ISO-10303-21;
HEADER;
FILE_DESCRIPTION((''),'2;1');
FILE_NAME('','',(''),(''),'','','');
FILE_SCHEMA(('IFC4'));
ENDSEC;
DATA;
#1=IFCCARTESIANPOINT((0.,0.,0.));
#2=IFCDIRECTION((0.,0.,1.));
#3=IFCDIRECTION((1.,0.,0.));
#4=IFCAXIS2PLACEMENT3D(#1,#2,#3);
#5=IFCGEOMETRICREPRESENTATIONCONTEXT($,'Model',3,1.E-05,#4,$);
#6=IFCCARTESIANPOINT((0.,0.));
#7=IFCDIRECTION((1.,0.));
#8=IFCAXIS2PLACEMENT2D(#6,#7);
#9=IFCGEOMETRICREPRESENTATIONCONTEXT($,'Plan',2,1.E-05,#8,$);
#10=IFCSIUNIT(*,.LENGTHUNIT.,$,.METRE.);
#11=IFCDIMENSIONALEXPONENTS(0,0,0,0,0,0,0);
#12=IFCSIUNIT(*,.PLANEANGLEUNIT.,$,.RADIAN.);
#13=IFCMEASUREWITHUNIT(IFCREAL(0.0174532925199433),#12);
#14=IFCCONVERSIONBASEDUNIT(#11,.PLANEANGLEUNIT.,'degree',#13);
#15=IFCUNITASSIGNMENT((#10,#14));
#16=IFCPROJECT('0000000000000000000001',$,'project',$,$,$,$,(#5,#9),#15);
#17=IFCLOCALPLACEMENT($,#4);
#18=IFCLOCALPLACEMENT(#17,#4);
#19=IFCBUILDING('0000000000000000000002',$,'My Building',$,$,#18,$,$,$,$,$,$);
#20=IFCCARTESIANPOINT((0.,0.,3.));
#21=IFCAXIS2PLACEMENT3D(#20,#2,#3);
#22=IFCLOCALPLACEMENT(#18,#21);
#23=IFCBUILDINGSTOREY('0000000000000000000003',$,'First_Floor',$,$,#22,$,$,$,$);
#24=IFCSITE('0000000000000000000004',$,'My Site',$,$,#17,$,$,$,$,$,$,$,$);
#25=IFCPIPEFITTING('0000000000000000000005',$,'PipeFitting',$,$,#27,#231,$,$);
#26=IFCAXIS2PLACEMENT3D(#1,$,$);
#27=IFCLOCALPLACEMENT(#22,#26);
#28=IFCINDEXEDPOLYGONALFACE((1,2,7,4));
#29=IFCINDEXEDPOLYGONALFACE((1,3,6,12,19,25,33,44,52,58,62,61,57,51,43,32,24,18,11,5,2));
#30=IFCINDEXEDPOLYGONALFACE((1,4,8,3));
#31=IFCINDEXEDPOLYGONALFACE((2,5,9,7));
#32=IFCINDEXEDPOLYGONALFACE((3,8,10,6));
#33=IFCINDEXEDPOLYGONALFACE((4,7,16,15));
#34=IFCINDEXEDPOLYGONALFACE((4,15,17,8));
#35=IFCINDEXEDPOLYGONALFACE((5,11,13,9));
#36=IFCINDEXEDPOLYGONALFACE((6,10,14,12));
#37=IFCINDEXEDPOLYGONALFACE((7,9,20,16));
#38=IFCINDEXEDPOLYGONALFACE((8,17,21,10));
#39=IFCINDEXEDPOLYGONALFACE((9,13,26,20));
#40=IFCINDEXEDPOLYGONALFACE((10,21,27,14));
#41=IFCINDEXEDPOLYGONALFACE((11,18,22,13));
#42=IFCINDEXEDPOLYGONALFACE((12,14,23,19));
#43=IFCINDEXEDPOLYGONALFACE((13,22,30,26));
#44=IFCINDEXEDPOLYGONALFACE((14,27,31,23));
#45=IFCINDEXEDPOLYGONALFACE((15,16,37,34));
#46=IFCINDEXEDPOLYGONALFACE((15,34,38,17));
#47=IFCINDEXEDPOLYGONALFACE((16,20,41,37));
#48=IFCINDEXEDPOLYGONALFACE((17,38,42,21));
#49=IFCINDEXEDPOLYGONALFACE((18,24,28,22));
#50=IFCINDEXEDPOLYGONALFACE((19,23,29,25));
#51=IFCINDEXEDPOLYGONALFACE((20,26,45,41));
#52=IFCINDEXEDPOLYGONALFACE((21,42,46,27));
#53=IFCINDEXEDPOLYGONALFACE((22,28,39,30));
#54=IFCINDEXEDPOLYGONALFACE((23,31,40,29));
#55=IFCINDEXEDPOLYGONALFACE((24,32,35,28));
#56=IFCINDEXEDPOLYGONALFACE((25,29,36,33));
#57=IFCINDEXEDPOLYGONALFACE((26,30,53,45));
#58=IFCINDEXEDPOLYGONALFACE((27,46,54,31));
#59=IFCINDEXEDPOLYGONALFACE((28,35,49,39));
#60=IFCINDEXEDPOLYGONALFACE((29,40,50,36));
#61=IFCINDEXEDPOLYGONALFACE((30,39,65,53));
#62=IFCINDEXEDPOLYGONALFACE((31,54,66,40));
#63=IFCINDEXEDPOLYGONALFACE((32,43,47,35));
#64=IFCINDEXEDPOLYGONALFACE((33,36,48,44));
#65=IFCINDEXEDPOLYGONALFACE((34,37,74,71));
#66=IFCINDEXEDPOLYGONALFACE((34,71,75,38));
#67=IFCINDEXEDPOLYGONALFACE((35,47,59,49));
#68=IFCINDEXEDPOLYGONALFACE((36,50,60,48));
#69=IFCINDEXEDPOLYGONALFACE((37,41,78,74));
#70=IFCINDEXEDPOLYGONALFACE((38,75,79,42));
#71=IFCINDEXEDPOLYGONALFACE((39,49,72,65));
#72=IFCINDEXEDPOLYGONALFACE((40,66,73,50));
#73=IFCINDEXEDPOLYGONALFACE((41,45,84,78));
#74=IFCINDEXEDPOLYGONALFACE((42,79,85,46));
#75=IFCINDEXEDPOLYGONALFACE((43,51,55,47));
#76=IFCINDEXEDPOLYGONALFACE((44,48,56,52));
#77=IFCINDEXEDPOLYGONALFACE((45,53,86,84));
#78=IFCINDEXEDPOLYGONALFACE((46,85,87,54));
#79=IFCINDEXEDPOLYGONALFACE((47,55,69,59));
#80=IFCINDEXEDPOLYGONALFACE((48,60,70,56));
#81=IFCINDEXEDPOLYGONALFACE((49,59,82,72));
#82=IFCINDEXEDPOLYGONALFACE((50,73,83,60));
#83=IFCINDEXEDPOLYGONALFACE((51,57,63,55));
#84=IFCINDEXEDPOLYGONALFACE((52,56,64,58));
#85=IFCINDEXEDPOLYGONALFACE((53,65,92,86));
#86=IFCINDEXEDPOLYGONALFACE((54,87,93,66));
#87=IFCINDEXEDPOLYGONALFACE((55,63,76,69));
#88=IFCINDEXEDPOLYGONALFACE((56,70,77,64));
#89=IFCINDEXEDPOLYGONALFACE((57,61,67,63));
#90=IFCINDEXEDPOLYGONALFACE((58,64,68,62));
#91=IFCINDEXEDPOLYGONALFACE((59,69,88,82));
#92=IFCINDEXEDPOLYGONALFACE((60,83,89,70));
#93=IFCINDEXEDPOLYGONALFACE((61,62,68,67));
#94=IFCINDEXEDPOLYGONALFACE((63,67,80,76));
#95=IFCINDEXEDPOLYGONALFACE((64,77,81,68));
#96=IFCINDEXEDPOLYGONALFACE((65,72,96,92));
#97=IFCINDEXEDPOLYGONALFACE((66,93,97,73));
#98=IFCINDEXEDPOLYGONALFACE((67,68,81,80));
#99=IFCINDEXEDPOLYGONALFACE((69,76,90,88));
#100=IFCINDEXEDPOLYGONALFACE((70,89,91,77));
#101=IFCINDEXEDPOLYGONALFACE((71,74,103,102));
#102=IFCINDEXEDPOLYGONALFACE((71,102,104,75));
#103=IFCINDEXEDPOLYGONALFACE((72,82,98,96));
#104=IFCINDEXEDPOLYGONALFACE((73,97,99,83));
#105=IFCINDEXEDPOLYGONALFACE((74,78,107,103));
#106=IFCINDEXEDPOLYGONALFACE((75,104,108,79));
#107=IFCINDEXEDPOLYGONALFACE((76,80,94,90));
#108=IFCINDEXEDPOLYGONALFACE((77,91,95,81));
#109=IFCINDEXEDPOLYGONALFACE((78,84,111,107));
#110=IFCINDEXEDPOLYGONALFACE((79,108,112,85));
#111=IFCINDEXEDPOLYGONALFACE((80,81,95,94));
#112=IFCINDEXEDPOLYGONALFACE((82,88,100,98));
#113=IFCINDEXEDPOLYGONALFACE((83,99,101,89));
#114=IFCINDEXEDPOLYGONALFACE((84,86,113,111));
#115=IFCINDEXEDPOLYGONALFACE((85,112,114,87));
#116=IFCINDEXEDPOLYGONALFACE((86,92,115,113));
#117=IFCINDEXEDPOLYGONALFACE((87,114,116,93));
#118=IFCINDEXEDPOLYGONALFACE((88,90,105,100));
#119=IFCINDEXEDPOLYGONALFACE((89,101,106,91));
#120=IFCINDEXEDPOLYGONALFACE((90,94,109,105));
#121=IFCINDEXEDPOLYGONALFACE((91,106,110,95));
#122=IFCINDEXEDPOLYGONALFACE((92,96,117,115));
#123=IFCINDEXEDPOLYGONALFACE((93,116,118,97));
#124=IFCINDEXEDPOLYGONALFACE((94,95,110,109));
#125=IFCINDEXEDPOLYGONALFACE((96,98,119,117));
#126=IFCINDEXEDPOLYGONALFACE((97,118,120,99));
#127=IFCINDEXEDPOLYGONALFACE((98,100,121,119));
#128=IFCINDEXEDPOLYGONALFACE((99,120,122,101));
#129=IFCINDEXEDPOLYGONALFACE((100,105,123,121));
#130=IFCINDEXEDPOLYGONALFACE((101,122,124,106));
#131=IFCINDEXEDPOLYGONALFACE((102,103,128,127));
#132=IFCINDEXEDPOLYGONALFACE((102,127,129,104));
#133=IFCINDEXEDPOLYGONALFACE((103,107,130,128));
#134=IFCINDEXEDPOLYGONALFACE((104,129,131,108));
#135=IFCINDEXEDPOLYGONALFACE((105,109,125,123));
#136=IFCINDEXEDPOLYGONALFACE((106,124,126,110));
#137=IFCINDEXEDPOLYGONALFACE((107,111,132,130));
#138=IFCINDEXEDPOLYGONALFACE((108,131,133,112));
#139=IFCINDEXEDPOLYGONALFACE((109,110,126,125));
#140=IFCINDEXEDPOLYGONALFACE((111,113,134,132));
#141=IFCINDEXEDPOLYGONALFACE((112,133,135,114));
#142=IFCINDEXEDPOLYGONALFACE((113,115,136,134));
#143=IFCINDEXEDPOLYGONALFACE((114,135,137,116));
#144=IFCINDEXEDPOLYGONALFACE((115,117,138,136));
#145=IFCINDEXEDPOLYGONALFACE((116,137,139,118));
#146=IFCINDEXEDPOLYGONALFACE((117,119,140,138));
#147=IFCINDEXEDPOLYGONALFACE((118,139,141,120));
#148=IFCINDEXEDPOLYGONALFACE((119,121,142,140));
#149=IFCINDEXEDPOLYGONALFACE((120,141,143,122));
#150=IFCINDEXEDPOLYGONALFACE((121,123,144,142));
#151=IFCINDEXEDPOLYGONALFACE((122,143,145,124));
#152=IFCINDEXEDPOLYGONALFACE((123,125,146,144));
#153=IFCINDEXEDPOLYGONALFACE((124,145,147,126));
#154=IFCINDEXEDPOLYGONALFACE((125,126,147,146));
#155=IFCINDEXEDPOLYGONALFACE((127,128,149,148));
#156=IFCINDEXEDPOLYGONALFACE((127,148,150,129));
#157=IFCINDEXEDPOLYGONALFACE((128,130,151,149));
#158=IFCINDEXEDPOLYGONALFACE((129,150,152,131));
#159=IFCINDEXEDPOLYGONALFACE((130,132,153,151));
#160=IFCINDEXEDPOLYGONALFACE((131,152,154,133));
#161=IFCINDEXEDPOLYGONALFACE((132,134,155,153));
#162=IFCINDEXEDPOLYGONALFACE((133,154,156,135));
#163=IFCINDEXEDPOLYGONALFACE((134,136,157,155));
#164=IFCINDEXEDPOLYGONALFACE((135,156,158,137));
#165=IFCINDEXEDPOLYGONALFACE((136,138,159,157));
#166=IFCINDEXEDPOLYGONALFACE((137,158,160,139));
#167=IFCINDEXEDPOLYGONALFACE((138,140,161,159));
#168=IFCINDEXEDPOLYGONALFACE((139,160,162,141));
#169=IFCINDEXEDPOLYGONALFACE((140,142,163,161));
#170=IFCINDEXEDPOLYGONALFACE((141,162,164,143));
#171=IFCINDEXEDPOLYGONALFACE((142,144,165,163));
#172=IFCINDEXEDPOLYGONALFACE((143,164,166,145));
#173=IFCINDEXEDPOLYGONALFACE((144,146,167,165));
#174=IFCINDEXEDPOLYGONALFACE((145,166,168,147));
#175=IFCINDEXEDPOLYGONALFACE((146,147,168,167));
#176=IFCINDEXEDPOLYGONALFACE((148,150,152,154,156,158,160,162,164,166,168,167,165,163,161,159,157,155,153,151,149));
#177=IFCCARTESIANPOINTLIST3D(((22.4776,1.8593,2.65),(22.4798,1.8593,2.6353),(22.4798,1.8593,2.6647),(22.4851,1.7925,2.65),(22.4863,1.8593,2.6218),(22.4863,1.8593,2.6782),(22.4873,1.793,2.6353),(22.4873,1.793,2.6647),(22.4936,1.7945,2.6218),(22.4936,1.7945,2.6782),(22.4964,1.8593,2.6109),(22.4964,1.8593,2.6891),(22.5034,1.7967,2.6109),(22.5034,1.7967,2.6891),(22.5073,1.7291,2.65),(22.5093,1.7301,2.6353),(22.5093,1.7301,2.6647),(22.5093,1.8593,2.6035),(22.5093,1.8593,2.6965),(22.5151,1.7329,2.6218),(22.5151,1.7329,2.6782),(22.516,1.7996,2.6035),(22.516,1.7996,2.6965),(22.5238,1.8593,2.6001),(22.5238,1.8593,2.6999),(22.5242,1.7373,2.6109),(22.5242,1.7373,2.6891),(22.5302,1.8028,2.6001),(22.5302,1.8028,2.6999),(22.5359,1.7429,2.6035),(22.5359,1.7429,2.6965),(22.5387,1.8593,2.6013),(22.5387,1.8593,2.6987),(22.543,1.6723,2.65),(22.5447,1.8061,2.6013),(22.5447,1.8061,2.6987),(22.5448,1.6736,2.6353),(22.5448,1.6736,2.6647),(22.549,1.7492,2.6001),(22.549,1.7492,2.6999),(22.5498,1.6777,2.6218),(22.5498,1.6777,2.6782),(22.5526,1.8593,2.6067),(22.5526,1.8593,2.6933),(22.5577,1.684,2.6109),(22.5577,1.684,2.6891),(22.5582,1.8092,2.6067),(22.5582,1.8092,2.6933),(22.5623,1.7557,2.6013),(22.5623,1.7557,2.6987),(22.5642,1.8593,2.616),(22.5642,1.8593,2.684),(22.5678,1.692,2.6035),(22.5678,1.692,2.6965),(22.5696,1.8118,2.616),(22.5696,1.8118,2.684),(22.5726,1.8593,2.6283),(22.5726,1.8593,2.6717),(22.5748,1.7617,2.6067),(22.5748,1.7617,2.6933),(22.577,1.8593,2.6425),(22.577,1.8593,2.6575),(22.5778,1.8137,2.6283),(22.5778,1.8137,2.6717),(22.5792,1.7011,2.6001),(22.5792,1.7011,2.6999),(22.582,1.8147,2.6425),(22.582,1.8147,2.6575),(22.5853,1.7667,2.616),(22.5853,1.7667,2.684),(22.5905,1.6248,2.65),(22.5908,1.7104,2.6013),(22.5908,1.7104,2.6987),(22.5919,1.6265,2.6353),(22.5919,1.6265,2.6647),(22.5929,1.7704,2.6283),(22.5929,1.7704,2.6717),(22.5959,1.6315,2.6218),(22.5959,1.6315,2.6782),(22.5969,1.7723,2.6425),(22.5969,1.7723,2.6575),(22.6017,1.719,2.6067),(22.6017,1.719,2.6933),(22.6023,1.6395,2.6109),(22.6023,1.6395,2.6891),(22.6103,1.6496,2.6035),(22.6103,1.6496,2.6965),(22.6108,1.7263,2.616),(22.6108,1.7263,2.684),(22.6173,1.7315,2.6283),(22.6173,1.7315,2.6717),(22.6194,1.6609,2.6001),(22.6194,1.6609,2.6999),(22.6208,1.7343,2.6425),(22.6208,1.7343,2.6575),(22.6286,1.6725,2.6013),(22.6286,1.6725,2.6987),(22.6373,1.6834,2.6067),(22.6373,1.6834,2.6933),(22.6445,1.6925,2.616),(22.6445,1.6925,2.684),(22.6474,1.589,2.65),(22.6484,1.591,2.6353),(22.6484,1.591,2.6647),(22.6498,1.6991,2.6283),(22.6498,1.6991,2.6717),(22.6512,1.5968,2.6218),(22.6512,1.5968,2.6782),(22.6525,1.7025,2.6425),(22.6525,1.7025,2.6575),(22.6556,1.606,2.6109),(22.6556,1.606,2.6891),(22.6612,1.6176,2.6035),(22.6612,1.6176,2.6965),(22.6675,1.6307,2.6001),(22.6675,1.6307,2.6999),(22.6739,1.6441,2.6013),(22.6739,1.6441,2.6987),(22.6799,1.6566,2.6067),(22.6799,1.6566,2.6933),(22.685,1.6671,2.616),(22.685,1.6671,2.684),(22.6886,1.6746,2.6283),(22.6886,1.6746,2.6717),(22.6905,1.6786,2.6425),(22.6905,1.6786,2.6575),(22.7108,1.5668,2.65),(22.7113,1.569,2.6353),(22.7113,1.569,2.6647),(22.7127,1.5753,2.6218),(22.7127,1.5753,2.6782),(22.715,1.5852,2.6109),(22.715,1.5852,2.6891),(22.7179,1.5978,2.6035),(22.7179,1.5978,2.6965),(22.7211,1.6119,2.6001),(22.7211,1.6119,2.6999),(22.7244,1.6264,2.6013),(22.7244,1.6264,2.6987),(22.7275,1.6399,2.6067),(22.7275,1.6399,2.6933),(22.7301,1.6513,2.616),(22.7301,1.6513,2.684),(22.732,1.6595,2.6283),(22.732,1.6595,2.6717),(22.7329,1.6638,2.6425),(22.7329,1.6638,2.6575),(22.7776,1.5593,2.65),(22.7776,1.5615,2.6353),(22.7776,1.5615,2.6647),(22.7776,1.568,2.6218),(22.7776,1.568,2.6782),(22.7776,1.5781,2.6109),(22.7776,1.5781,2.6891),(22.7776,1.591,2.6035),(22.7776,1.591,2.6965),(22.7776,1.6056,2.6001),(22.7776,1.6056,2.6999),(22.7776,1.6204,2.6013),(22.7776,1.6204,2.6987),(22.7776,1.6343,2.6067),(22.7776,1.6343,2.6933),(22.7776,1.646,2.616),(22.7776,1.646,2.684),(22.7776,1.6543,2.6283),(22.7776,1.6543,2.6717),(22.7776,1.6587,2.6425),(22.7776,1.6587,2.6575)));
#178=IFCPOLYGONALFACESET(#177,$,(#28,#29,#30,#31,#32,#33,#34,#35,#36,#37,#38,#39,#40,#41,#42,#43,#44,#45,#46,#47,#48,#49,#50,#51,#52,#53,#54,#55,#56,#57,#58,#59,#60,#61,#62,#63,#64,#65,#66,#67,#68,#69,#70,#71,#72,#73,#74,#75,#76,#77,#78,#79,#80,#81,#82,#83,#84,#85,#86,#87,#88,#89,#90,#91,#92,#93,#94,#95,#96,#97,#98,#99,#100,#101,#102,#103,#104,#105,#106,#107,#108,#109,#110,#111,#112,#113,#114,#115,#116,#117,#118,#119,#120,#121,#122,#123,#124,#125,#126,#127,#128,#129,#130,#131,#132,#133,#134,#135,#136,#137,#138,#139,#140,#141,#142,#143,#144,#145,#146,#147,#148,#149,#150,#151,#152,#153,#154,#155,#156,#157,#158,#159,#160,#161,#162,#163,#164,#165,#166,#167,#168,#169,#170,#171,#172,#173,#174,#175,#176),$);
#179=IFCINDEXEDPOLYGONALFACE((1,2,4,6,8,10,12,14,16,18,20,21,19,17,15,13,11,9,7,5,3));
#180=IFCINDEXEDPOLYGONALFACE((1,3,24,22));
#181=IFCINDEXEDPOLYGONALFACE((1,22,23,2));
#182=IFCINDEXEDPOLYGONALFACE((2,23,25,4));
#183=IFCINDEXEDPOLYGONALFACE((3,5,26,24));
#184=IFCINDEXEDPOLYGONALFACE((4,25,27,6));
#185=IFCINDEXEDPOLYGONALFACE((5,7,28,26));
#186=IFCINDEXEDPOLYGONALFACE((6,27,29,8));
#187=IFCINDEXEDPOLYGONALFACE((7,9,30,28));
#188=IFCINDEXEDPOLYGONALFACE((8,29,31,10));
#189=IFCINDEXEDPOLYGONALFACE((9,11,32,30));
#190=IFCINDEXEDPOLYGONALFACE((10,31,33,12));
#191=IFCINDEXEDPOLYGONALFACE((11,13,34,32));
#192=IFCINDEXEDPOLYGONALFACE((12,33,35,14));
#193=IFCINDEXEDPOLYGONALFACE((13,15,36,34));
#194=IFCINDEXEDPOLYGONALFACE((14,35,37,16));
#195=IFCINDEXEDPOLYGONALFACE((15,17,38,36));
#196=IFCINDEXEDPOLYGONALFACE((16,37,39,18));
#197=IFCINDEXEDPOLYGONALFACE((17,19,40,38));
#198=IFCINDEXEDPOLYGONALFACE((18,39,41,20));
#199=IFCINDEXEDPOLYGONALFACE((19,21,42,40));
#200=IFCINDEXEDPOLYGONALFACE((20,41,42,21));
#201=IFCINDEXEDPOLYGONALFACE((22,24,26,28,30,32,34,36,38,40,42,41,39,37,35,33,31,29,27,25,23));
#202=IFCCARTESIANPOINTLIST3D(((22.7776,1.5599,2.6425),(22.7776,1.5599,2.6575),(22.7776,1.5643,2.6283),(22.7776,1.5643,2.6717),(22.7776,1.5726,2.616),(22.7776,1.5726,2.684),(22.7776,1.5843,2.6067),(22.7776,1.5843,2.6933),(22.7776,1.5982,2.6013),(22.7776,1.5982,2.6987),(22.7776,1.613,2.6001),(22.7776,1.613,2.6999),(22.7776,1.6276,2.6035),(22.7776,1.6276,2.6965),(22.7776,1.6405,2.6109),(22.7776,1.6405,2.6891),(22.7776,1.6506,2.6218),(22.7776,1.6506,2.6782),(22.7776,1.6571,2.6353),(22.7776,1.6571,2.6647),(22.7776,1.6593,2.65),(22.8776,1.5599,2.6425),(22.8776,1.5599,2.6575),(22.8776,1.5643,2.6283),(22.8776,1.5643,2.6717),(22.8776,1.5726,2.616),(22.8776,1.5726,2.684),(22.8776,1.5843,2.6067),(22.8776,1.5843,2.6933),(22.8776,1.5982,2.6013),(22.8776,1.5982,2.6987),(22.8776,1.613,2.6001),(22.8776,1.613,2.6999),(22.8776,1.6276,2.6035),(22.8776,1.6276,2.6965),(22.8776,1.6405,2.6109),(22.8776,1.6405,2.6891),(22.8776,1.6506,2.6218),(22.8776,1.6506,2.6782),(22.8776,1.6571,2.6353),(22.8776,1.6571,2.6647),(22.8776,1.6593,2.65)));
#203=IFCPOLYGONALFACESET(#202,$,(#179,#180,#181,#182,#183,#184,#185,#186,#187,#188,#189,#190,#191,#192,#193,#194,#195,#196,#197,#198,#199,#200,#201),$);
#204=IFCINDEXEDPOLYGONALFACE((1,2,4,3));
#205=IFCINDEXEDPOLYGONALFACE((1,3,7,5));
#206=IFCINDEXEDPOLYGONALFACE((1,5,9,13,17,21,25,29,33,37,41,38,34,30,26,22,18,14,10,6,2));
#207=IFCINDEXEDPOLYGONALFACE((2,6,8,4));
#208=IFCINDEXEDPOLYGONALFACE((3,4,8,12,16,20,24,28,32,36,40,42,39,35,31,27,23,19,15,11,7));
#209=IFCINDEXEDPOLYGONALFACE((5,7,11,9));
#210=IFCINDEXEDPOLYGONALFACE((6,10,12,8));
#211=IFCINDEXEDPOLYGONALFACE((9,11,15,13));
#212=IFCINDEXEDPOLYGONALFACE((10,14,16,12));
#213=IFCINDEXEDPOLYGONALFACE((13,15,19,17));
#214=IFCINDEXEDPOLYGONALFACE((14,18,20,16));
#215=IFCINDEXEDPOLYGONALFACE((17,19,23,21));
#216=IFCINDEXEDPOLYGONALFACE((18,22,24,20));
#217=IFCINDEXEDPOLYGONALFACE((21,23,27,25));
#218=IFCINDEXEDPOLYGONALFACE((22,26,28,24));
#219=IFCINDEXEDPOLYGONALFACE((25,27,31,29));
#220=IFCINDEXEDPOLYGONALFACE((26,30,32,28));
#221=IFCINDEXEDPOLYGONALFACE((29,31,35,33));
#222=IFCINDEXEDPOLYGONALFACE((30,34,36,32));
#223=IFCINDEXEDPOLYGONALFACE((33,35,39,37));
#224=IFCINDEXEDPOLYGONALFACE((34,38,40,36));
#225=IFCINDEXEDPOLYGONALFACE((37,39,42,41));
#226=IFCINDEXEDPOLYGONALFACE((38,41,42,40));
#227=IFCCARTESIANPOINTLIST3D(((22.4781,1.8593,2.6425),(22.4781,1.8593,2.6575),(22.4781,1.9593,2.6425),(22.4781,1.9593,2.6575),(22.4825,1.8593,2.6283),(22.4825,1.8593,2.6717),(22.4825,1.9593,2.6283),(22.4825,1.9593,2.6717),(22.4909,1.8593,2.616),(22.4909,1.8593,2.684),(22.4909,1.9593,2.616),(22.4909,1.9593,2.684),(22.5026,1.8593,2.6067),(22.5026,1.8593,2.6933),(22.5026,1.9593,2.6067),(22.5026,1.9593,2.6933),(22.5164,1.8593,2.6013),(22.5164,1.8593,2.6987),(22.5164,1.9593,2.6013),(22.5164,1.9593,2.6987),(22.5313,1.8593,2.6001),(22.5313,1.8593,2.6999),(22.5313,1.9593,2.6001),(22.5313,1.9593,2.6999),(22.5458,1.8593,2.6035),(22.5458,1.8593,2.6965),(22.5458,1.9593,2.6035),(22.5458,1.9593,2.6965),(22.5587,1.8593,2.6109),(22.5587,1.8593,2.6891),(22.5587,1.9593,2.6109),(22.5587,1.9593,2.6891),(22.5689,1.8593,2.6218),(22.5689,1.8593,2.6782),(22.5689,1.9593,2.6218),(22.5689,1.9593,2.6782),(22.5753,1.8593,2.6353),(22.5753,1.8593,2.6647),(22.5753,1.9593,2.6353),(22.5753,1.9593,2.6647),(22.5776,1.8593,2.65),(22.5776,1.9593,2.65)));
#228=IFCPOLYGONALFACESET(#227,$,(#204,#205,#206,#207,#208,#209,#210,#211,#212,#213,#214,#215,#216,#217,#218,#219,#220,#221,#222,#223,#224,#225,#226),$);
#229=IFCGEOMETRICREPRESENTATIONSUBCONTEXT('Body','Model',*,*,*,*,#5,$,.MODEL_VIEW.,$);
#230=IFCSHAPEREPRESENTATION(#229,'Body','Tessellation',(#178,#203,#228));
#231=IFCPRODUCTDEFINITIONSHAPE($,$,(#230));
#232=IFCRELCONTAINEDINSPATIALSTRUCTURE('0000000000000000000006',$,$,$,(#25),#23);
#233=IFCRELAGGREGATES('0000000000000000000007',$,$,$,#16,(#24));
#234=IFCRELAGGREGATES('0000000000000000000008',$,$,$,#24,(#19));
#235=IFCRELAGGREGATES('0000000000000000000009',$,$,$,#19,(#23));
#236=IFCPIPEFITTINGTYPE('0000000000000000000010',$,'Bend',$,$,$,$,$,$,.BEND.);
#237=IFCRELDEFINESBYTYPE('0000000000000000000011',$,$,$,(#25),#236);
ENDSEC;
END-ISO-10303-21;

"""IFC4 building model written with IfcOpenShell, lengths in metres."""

from ifc_helpers import new_model, entity, si_unit, converted_unit, frame, origin_with_axes, origin_2d_with_axis, place, context, subcontext, project, spatial, circle, extrude, source, transform, mapped, type_object, type_shapes, element, save


model = new_model("IFC4")

# Units and contexts
model_context = context("Model", 3, precision=1e-05, world=origin_with_axes())
plan_context = context("Plan", 2, precision=1e-05, world=origin_2d_with_axis())
body_context = subcontext(model_context, "Body", "Model", "MODEL_VIEW")
ifc_project = project(units=[si_unit("LENGTHUNIT", "METRE"), converted_unit("PLANEANGLEUNIT", "degree", entity("IfcReal", 0.0174532925199433), si_unit("PLANEANGLEUNIT", "RADIAN"), dimensions=[0, 0, 0, 0, 0, 0, 0])], contexts=[model_context, plan_context])

# Site, building, storey
site_placement = place(None, origin_with_axes())
site = spatial("IfcSite", under=ifc_project, at=site_placement, Name="My Site")
building_placement = place(site_placement, origin_with_axes())
building = spatial("IfcBuilding", under=site, at=building_placement, Name="My Building")
storey_placement = place(building_placement, frame((0.0, 0.0, 3.0), z_axis=(0.0, 0.0, 1.0), x_axis=(1.0, 0.0, 0.0)))
storey = spatial("IfcBuildingStorey", under=building, at=storey_placement, Name="First_Floor")

# Pipe fitting
pipe_fitting_type = type_object("IfcPipeFittingType", Name="Bend", PredefinedType="BEND")
shared_shape_1 = source(origin_with_axes(), body_context, "Body", "SolidModel", [
    entity("IfcSweptDiskSolid", entity("IfcIndexedPolyCurve", entity("IfcCartesianPointList3D", [[0.0, 0.0, -0.1], [0.0732, 0.0, -0.2768], [0.25, 0.0, -0.35]]), [entity("IfcArcIndex", [1, 2, 3])]), 0.05),
    extrude(circle(Radius=0.05), origin_with_axes(), (0.0, 0.0, -1.0), 0.1),
    extrude(circle(Radius=0.05), frame((0.25, 0.0, -0.35), z_axis=(1.0, 0.0, 0.0), x_axis=(0.0, 0.0, 1.0)), (0.0, 0.0, 1.0), 0.1),
])
type_shapes(pipe_fitting_type, [shared_shape_1])
for number, where, z_axis, x_axis, name in (
    (1, (22.8776, 1.6093, 2.65), (1.0, 0.0, 0.0), (0.0, 1.0, 0.0), "PipeFitting"),
):
    element("IfcPipeFitting", number, at=place(storey_placement, frame(where, z_axis=z_axis, x_axis=x_axis)), inside=storey, type_object=pipe_fitting_type, Name=name, context=body_context, shape_type="MappedRepresentation", body=[
        mapped(shared_shape_1, transform((0.0, 0.0, 0.0), x_axis=(1.0, 0.0, 0.0), y_axis=(0.0, 1.0, 0.0), z_axis=(0.0, 0.0, 1.0), scale=1.0)),
    ])

save(model, "model.ifc")
